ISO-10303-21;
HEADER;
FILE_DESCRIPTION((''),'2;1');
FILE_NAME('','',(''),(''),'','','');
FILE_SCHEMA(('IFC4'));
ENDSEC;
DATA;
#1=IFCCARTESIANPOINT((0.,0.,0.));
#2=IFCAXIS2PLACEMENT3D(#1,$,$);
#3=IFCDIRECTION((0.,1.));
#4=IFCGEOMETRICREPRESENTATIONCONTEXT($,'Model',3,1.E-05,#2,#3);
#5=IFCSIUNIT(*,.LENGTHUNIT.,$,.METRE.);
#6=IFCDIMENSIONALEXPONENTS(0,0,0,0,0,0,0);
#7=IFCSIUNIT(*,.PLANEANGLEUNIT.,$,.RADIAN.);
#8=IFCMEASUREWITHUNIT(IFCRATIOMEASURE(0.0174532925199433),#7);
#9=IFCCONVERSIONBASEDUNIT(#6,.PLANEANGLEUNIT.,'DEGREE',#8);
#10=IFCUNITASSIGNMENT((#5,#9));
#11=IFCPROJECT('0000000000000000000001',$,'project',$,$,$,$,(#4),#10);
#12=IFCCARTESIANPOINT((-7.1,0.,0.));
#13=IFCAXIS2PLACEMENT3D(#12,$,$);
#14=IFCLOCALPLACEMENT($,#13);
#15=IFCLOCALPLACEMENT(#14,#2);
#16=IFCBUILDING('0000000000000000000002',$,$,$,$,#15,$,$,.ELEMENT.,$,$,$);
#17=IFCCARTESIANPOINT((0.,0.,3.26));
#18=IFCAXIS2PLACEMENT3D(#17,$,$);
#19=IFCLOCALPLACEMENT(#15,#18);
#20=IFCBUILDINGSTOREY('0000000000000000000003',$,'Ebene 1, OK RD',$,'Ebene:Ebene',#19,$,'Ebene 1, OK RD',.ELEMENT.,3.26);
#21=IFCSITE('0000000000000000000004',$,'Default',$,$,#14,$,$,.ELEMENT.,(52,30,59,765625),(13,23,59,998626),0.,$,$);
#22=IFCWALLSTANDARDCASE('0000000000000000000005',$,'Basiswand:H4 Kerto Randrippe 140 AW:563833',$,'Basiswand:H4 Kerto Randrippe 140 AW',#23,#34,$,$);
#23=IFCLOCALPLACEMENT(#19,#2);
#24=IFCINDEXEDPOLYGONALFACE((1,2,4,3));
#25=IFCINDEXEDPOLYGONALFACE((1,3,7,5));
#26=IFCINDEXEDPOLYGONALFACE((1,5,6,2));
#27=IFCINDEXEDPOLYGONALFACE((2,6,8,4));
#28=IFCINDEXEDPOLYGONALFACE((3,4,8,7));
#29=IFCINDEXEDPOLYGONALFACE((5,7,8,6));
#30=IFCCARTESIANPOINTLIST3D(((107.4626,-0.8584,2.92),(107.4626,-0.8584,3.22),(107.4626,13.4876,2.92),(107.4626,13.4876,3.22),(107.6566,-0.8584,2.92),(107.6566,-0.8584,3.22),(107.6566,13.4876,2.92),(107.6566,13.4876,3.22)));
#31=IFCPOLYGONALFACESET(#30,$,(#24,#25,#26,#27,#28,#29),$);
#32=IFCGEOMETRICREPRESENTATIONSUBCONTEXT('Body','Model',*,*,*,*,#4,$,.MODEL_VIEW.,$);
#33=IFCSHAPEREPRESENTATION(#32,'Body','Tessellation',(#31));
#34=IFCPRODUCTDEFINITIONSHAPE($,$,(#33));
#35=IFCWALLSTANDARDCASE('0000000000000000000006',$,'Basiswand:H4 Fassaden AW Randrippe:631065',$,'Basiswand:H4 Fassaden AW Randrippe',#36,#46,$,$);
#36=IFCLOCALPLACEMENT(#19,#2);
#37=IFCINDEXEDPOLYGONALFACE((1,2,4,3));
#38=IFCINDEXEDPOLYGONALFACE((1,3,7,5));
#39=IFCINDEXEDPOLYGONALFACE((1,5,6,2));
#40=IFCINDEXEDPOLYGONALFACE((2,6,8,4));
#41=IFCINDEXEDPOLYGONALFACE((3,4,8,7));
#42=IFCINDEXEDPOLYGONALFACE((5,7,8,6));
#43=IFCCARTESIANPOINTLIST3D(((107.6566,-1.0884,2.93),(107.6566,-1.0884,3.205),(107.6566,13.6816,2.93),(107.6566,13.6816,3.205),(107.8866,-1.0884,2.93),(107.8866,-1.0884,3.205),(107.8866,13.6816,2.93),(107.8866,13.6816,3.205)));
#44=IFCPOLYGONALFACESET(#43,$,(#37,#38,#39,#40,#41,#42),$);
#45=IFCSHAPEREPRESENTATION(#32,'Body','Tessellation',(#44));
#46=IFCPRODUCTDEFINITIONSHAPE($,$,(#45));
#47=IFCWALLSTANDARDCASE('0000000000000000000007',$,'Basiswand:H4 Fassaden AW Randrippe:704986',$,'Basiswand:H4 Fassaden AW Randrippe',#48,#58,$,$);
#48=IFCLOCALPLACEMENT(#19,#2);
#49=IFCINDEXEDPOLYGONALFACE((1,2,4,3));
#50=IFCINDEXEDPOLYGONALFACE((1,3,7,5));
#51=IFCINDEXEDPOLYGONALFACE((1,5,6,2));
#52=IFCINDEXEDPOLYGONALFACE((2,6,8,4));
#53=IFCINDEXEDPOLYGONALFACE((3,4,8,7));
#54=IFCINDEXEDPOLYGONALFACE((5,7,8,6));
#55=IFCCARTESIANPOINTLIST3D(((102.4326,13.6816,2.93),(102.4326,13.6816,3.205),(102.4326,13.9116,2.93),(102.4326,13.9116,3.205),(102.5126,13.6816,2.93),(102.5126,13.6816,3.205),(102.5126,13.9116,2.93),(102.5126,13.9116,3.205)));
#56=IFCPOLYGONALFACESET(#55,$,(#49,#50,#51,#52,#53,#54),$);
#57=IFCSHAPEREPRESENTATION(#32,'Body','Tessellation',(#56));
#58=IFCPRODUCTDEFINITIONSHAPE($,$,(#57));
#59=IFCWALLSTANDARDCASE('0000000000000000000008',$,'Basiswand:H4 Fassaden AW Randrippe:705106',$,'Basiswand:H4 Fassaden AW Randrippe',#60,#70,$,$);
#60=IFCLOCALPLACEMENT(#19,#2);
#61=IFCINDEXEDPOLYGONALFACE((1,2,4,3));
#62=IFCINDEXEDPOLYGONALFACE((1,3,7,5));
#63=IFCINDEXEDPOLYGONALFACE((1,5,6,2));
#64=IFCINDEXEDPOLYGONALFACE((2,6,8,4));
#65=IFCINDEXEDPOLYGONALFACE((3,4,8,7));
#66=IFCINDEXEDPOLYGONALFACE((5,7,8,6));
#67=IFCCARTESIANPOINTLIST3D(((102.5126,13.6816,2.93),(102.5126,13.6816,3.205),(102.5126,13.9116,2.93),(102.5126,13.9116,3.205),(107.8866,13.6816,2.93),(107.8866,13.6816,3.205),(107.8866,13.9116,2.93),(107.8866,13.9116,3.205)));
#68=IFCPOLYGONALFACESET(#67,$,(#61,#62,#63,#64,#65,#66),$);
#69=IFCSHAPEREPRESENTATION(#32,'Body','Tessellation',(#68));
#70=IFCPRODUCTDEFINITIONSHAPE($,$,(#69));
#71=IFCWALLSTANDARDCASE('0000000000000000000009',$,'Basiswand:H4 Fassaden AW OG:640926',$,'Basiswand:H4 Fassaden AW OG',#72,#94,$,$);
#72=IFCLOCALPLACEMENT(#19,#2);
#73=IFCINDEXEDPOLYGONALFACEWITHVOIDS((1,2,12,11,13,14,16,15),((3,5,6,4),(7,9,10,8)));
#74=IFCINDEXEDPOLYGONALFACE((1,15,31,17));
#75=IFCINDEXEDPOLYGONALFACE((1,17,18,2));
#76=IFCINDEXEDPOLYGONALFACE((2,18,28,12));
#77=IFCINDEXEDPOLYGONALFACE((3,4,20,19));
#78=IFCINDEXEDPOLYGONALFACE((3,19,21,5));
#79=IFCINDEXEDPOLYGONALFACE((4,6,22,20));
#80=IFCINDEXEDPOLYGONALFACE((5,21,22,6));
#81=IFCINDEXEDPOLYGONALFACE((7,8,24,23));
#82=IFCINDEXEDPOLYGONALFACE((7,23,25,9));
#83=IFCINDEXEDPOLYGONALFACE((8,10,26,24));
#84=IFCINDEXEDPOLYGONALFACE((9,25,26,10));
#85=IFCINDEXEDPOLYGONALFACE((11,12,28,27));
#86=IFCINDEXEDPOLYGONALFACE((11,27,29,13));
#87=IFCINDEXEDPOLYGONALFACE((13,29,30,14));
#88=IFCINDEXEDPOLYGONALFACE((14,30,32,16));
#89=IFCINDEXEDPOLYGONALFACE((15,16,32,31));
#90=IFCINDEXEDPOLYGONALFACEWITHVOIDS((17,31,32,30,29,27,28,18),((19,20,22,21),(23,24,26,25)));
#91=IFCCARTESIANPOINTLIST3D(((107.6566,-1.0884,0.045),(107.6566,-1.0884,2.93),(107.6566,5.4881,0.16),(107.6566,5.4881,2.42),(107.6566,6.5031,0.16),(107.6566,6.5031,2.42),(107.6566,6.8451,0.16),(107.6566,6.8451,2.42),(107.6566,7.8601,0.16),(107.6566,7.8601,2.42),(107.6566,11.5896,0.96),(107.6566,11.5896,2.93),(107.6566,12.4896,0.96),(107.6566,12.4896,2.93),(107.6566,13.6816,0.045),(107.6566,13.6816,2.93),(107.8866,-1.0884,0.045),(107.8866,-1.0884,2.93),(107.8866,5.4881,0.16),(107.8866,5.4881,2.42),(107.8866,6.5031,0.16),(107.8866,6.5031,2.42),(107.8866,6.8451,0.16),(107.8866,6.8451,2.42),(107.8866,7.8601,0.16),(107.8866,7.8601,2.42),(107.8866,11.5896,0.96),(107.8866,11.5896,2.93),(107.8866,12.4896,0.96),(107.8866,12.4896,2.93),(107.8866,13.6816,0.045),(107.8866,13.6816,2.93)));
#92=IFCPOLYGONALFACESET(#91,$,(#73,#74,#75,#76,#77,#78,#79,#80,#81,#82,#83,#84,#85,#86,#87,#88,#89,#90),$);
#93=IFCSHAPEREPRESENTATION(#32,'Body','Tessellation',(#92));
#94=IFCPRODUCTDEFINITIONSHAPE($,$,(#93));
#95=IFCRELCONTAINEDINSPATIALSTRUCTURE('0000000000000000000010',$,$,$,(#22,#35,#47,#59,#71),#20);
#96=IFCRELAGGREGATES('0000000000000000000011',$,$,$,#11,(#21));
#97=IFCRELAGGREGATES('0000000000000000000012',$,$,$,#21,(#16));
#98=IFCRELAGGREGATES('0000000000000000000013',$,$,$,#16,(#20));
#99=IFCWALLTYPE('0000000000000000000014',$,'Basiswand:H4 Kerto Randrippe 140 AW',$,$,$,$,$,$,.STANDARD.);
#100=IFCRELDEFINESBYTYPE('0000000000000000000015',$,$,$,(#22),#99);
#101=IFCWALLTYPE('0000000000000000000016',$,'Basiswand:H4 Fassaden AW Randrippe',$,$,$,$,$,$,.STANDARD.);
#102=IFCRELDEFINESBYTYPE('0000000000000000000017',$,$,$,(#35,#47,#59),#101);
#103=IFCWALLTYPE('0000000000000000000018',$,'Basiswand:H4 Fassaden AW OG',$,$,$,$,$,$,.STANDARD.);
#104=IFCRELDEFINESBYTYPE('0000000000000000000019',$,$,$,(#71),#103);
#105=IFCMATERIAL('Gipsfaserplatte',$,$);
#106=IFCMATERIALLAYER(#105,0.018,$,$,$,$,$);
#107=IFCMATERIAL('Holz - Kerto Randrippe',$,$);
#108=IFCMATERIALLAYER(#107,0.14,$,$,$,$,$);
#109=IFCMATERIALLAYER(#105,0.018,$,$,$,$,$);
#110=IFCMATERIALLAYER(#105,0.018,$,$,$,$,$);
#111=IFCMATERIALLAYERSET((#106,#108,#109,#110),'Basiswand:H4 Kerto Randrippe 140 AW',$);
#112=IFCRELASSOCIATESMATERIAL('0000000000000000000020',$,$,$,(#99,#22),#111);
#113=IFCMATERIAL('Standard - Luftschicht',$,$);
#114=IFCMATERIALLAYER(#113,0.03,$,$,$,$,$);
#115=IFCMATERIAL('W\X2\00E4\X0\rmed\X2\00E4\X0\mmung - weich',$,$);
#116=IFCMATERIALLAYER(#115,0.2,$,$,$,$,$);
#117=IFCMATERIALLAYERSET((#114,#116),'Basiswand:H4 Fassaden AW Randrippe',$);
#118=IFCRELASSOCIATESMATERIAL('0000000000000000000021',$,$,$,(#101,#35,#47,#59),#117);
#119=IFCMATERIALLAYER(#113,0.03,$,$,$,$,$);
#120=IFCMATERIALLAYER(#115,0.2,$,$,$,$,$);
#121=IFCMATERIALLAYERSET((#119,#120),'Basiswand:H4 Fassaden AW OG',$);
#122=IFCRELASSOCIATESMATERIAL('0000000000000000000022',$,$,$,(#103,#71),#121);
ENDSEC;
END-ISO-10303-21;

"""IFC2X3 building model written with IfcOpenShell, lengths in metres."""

from ifc_helpers import new_model, entity, si_unit, converted_unit, direction, frame, frame_2d, origin, place, context, subcontext, project, spatial, rectangle, extrude, material, layer, layer_set, layer_usage, type_object, element, save


model = new_model("IFC2X3")

# Units and contexts
model_context = context("Model", 3, precision=1e-05, world=origin(), true_north=direction((0.0, 1.0)))
body_context = subcontext(model_context, "Body", "Model", "MODEL_VIEW")
ifc_project = project(units=[si_unit("LENGTHUNIT", "METRE"), converted_unit("PLANEANGLEUNIT", "DEGREE", entity("IfcRatioMeasure", 0.0174532925199433), si_unit("PLANEANGLEUNIT", "RADIAN"), dimensions=[0, 0, 0, 0, 0, 0, 0])], contexts=[model_context])

# Site, building, storey
site_placement = place(None, frame((-7.1, 0.0, 0.0)))
site = spatial("IfcSite", under=ifc_project, at=site_placement, Name="Default", CompositionType="ELEMENT", RefLatitude=(52, 30, 59, 765625), RefLongitude=(13, 23, 59, 998626), RefElevation=0.0)
building_placement = place(site_placement, origin())
building = spatial("IfcBuilding", under=site, at=building_placement, CompositionType="ELEMENT")
storey_placement = place(building_placement, frame((0.0, 0.0, 3.26)))
storey = spatial("IfcBuildingStorey", under=building, at=storey_placement, Name="Ebene 1, OK RD", ObjectType="Ebene:Ebene", LongName="Ebene 1, OK RD", CompositionType="ELEMENT", Elevation=3.26)

# Shared definitions
ifc_material_1 = material(Name="Gipsfaserplatte")

# Walls
ifc_layer_1 = layer(ifc_material_1, 0.018)
ifc_material_2 = material(Name="Holz - Kerto Randrippe")
ifc_layer_2 = layer(ifc_material_2, 0.14)
ifc_layer_3 = layer(ifc_material_1, 0.018)
ifc_layer_4 = layer(ifc_material_1, 0.018)
ifc_layer_set_1 = layer_set([ifc_layer_1, ifc_layer_2, ifc_layer_3, ifc_layer_4], Name="Basiswand:H4 Kerto Randrippe 140 AW")
ifc_layer_usage_1 = layer_usage(ifc_layer_set_1, "AXIS2", "NEGATIVE", 0.097)
wall_type_1 = type_object("IfcWallType", Name="Basiswand:H4 Kerto Randrippe 140 AW", PredefinedType="STANDARD", material=ifc_layer_set_1)
wall_1_placement = place(storey_placement, frame((107.5596, 13.4876, 2.92), z_axis=(0.0, 0.0, 1.0), x_axis=(0.0, -1.0, 0.0)))
element("IfcWallStandardCase", 1, at=wall_1_placement, inside=storey, type_object=wall_type_1, material=ifc_layer_usage_1, Name="Basiswand:H4 Kerto Randrippe 140 AW:563833", ObjectType="Basiswand:H4 Kerto Randrippe 140 AW", context=body_context, shape_type="SweptSolid", body=[
    extrude(rectangle(XDim=14.346, YDim=0.194, at=frame_2d((7.173, 0.0), x_axis=(-1.0, 0.0))), origin(), (0.0, 0.0, 1.0), 0.3),
])
ifc_material_3 = material(Name="Standard - Luftschicht")
ifc_layer_5 = layer(ifc_material_3, 0.03)
ifc_material_4 = material(Name="Wärmedämmung - weich")
ifc_layer_6 = layer(ifc_material_4, 0.2)
ifc_layer_set_2 = layer_set([ifc_layer_5, ifc_layer_6], Name="Basiswand:H4 Fassaden AW Randrippe")
ifc_layer_usage_2 = layer_usage(ifc_layer_set_2, "AXIS2", "NEGATIVE", 0.115)
wall_type_2 = type_object("IfcWallType", Name="Basiswand:H4 Fassaden AW Randrippe", PredefinedType="STANDARD", material=ifc_layer_set_2)
wall_2_placement = place(storey_placement, frame((107.7716, 13.6816, 2.93), z_axis=(0.0, 0.0, 1.0), x_axis=(0.0, -1.0, 0.0)))
element("IfcWallStandardCase", 2, at=wall_2_placement, inside=storey, type_object=wall_type_2, material=ifc_layer_usage_2, Name="Basiswand:H4 Fassaden AW Randrippe:631065", ObjectType="Basiswand:H4 Fassaden AW Randrippe", context=body_context, shape_type="SweptSolid", body=[
    extrude(rectangle(XDim=14.77, YDim=0.23, at=frame_2d((7.385, 0.0), x_axis=(-1.0, 0.0))), origin(), (0.0, 0.0, 1.0), 0.275),
])
ifc_layer_usage_3 = layer_usage(ifc_layer_set_2, "AXIS2", "NEGATIVE", 0.115)
wall_3_placement = place(storey_placement, frame((102.4326, 13.7966, 2.93)))
element("IfcWallStandardCase", 3, at=wall_3_placement, inside=storey, type_object=wall_type_2, material=ifc_layer_usage_3, Name="Basiswand:H4 Fassaden AW Randrippe:704986", ObjectType="Basiswand:H4 Fassaden AW Randrippe", context=body_context, shape_type="SweptSolid", body=[
    extrude(rectangle(XDim=0.08, YDim=0.23, at=frame_2d((0.04, 0.0), x_axis=(-1.0, 0.0))), origin(), (0.0, 0.0, 1.0), 0.275),
])
ifc_layer_usage_4 = layer_usage(ifc_layer_set_2, "AXIS2", "NEGATIVE", 0.115)
wall_4_placement = place(storey_placement, frame((102.5126, 13.7966, 2.93)))
element("IfcWallStandardCase", 4, at=wall_4_placement, inside=storey, type_object=wall_type_2, material=ifc_layer_usage_4, Name="Basiswand:H4 Fassaden AW Randrippe:705106", ObjectType="Basiswand:H4 Fassaden AW Randrippe", context=body_context, shape_type="SweptSolid", body=[
    extrude(rectangle(XDim=5.374, YDim=0.23, at=frame_2d((2.687, 0.0), x_axis=(-1.0, 0.0))), origin(), (0.0, 0.0, 1.0), 0.275),
])

# Wall, openings
ifc_layer_7 = layer(ifc_material_3, 0.03)
ifc_layer_8 = layer(ifc_material_4, 0.2)
ifc_layer_set_3 = layer_set([ifc_layer_7, ifc_layer_8], Name="Basiswand:H4 Fassaden AW OG")
ifc_layer_usage_5 = layer_usage(ifc_layer_set_3, "AXIS2", "NEGATIVE", 0.115)
wall_type_3 = type_object("IfcWallType", Name="Basiswand:H4 Fassaden AW OG", PredefinedType="STANDARD", material=ifc_layer_set_3)
wall_5_placement = place(storey_placement, frame((107.7716, 13.6816, 0.045), z_axis=(0.0, 0.0, 1.0), x_axis=(0.0, -1.0, 0.0)))
wall_5 = element("IfcWallStandardCase", 5, at=wall_5_placement, inside=storey, type_object=wall_type_3, material=ifc_layer_usage_5, Name="Basiswand:H4 Fassaden AW OG:640926", ObjectType="Basiswand:H4 Fassaden AW OG", context=body_context, shape_type="SweptSolid", body=[
    extrude(rectangle(XDim=14.77, YDim=0.23, at=frame_2d((7.385, 0.0), x_axis=(-1.0, 0.0))), origin(), (0.0, 0.0, 1.0), 2.885),
])
opening_1_placement = place(wall_5_placement, frame((2.092, 0.115, 0.915)))
element("IfcOpeningElement", 6, at=opening_1_placement, cuts=wall_5, ObjectType="Opening", context=body_context, shape_type="SweptSolid", body=[
    extrude(rectangle(XDim=1.97, YDim=0.9, at=frame_2d((0.985, 0.45), x_axis=(1.0, 0.0))), frame((0.0, 0.0, 0.0), z_axis=(0.0, -1.0, 0.0), x_axis=(0.0, 0.0, 1.0)), (0.0, 0.0, 1.0), 0.23),
])
opening_2_placement = place(wall_5_placement, frame((8.1935, 0.115, 0.115)))
element("IfcOpeningElement", 7, at=opening_2_placement, cuts=wall_5, ObjectType="Opening", context=body_context, shape_type="SweptSolid", body=[
    extrude(rectangle(XDim=2.26, YDim=1.015, at=frame_2d((1.13, 0.5075), x_axis=(1.0, 0.0))), frame((0.0, 0.0, 0.0), z_axis=(0.0, -1.0, 0.0), x_axis=(0.0, 0.0, 1.0)), (0.0, 0.0, 1.0), 0.23),
])
opening_3_placement = place(wall_5_placement, frame((6.8365, 0.115, 0.115)))
element("IfcOpeningElement", 8, at=opening_3_placement, cuts=wall_5, ObjectType="Opening", context=body_context, shape_type="SweptSolid", body=[
    extrude(rectangle(XDim=2.26, YDim=1.015, at=frame_2d((1.13, 0.5075), x_axis=(1.0, 0.0))), frame((0.0, 0.0, 0.0), z_axis=(0.0, -1.0, 0.0), x_axis=(0.0, 0.0, 1.0)), (0.0, 0.0, 1.0), 0.23),
])

save(model, "model.ifc")
